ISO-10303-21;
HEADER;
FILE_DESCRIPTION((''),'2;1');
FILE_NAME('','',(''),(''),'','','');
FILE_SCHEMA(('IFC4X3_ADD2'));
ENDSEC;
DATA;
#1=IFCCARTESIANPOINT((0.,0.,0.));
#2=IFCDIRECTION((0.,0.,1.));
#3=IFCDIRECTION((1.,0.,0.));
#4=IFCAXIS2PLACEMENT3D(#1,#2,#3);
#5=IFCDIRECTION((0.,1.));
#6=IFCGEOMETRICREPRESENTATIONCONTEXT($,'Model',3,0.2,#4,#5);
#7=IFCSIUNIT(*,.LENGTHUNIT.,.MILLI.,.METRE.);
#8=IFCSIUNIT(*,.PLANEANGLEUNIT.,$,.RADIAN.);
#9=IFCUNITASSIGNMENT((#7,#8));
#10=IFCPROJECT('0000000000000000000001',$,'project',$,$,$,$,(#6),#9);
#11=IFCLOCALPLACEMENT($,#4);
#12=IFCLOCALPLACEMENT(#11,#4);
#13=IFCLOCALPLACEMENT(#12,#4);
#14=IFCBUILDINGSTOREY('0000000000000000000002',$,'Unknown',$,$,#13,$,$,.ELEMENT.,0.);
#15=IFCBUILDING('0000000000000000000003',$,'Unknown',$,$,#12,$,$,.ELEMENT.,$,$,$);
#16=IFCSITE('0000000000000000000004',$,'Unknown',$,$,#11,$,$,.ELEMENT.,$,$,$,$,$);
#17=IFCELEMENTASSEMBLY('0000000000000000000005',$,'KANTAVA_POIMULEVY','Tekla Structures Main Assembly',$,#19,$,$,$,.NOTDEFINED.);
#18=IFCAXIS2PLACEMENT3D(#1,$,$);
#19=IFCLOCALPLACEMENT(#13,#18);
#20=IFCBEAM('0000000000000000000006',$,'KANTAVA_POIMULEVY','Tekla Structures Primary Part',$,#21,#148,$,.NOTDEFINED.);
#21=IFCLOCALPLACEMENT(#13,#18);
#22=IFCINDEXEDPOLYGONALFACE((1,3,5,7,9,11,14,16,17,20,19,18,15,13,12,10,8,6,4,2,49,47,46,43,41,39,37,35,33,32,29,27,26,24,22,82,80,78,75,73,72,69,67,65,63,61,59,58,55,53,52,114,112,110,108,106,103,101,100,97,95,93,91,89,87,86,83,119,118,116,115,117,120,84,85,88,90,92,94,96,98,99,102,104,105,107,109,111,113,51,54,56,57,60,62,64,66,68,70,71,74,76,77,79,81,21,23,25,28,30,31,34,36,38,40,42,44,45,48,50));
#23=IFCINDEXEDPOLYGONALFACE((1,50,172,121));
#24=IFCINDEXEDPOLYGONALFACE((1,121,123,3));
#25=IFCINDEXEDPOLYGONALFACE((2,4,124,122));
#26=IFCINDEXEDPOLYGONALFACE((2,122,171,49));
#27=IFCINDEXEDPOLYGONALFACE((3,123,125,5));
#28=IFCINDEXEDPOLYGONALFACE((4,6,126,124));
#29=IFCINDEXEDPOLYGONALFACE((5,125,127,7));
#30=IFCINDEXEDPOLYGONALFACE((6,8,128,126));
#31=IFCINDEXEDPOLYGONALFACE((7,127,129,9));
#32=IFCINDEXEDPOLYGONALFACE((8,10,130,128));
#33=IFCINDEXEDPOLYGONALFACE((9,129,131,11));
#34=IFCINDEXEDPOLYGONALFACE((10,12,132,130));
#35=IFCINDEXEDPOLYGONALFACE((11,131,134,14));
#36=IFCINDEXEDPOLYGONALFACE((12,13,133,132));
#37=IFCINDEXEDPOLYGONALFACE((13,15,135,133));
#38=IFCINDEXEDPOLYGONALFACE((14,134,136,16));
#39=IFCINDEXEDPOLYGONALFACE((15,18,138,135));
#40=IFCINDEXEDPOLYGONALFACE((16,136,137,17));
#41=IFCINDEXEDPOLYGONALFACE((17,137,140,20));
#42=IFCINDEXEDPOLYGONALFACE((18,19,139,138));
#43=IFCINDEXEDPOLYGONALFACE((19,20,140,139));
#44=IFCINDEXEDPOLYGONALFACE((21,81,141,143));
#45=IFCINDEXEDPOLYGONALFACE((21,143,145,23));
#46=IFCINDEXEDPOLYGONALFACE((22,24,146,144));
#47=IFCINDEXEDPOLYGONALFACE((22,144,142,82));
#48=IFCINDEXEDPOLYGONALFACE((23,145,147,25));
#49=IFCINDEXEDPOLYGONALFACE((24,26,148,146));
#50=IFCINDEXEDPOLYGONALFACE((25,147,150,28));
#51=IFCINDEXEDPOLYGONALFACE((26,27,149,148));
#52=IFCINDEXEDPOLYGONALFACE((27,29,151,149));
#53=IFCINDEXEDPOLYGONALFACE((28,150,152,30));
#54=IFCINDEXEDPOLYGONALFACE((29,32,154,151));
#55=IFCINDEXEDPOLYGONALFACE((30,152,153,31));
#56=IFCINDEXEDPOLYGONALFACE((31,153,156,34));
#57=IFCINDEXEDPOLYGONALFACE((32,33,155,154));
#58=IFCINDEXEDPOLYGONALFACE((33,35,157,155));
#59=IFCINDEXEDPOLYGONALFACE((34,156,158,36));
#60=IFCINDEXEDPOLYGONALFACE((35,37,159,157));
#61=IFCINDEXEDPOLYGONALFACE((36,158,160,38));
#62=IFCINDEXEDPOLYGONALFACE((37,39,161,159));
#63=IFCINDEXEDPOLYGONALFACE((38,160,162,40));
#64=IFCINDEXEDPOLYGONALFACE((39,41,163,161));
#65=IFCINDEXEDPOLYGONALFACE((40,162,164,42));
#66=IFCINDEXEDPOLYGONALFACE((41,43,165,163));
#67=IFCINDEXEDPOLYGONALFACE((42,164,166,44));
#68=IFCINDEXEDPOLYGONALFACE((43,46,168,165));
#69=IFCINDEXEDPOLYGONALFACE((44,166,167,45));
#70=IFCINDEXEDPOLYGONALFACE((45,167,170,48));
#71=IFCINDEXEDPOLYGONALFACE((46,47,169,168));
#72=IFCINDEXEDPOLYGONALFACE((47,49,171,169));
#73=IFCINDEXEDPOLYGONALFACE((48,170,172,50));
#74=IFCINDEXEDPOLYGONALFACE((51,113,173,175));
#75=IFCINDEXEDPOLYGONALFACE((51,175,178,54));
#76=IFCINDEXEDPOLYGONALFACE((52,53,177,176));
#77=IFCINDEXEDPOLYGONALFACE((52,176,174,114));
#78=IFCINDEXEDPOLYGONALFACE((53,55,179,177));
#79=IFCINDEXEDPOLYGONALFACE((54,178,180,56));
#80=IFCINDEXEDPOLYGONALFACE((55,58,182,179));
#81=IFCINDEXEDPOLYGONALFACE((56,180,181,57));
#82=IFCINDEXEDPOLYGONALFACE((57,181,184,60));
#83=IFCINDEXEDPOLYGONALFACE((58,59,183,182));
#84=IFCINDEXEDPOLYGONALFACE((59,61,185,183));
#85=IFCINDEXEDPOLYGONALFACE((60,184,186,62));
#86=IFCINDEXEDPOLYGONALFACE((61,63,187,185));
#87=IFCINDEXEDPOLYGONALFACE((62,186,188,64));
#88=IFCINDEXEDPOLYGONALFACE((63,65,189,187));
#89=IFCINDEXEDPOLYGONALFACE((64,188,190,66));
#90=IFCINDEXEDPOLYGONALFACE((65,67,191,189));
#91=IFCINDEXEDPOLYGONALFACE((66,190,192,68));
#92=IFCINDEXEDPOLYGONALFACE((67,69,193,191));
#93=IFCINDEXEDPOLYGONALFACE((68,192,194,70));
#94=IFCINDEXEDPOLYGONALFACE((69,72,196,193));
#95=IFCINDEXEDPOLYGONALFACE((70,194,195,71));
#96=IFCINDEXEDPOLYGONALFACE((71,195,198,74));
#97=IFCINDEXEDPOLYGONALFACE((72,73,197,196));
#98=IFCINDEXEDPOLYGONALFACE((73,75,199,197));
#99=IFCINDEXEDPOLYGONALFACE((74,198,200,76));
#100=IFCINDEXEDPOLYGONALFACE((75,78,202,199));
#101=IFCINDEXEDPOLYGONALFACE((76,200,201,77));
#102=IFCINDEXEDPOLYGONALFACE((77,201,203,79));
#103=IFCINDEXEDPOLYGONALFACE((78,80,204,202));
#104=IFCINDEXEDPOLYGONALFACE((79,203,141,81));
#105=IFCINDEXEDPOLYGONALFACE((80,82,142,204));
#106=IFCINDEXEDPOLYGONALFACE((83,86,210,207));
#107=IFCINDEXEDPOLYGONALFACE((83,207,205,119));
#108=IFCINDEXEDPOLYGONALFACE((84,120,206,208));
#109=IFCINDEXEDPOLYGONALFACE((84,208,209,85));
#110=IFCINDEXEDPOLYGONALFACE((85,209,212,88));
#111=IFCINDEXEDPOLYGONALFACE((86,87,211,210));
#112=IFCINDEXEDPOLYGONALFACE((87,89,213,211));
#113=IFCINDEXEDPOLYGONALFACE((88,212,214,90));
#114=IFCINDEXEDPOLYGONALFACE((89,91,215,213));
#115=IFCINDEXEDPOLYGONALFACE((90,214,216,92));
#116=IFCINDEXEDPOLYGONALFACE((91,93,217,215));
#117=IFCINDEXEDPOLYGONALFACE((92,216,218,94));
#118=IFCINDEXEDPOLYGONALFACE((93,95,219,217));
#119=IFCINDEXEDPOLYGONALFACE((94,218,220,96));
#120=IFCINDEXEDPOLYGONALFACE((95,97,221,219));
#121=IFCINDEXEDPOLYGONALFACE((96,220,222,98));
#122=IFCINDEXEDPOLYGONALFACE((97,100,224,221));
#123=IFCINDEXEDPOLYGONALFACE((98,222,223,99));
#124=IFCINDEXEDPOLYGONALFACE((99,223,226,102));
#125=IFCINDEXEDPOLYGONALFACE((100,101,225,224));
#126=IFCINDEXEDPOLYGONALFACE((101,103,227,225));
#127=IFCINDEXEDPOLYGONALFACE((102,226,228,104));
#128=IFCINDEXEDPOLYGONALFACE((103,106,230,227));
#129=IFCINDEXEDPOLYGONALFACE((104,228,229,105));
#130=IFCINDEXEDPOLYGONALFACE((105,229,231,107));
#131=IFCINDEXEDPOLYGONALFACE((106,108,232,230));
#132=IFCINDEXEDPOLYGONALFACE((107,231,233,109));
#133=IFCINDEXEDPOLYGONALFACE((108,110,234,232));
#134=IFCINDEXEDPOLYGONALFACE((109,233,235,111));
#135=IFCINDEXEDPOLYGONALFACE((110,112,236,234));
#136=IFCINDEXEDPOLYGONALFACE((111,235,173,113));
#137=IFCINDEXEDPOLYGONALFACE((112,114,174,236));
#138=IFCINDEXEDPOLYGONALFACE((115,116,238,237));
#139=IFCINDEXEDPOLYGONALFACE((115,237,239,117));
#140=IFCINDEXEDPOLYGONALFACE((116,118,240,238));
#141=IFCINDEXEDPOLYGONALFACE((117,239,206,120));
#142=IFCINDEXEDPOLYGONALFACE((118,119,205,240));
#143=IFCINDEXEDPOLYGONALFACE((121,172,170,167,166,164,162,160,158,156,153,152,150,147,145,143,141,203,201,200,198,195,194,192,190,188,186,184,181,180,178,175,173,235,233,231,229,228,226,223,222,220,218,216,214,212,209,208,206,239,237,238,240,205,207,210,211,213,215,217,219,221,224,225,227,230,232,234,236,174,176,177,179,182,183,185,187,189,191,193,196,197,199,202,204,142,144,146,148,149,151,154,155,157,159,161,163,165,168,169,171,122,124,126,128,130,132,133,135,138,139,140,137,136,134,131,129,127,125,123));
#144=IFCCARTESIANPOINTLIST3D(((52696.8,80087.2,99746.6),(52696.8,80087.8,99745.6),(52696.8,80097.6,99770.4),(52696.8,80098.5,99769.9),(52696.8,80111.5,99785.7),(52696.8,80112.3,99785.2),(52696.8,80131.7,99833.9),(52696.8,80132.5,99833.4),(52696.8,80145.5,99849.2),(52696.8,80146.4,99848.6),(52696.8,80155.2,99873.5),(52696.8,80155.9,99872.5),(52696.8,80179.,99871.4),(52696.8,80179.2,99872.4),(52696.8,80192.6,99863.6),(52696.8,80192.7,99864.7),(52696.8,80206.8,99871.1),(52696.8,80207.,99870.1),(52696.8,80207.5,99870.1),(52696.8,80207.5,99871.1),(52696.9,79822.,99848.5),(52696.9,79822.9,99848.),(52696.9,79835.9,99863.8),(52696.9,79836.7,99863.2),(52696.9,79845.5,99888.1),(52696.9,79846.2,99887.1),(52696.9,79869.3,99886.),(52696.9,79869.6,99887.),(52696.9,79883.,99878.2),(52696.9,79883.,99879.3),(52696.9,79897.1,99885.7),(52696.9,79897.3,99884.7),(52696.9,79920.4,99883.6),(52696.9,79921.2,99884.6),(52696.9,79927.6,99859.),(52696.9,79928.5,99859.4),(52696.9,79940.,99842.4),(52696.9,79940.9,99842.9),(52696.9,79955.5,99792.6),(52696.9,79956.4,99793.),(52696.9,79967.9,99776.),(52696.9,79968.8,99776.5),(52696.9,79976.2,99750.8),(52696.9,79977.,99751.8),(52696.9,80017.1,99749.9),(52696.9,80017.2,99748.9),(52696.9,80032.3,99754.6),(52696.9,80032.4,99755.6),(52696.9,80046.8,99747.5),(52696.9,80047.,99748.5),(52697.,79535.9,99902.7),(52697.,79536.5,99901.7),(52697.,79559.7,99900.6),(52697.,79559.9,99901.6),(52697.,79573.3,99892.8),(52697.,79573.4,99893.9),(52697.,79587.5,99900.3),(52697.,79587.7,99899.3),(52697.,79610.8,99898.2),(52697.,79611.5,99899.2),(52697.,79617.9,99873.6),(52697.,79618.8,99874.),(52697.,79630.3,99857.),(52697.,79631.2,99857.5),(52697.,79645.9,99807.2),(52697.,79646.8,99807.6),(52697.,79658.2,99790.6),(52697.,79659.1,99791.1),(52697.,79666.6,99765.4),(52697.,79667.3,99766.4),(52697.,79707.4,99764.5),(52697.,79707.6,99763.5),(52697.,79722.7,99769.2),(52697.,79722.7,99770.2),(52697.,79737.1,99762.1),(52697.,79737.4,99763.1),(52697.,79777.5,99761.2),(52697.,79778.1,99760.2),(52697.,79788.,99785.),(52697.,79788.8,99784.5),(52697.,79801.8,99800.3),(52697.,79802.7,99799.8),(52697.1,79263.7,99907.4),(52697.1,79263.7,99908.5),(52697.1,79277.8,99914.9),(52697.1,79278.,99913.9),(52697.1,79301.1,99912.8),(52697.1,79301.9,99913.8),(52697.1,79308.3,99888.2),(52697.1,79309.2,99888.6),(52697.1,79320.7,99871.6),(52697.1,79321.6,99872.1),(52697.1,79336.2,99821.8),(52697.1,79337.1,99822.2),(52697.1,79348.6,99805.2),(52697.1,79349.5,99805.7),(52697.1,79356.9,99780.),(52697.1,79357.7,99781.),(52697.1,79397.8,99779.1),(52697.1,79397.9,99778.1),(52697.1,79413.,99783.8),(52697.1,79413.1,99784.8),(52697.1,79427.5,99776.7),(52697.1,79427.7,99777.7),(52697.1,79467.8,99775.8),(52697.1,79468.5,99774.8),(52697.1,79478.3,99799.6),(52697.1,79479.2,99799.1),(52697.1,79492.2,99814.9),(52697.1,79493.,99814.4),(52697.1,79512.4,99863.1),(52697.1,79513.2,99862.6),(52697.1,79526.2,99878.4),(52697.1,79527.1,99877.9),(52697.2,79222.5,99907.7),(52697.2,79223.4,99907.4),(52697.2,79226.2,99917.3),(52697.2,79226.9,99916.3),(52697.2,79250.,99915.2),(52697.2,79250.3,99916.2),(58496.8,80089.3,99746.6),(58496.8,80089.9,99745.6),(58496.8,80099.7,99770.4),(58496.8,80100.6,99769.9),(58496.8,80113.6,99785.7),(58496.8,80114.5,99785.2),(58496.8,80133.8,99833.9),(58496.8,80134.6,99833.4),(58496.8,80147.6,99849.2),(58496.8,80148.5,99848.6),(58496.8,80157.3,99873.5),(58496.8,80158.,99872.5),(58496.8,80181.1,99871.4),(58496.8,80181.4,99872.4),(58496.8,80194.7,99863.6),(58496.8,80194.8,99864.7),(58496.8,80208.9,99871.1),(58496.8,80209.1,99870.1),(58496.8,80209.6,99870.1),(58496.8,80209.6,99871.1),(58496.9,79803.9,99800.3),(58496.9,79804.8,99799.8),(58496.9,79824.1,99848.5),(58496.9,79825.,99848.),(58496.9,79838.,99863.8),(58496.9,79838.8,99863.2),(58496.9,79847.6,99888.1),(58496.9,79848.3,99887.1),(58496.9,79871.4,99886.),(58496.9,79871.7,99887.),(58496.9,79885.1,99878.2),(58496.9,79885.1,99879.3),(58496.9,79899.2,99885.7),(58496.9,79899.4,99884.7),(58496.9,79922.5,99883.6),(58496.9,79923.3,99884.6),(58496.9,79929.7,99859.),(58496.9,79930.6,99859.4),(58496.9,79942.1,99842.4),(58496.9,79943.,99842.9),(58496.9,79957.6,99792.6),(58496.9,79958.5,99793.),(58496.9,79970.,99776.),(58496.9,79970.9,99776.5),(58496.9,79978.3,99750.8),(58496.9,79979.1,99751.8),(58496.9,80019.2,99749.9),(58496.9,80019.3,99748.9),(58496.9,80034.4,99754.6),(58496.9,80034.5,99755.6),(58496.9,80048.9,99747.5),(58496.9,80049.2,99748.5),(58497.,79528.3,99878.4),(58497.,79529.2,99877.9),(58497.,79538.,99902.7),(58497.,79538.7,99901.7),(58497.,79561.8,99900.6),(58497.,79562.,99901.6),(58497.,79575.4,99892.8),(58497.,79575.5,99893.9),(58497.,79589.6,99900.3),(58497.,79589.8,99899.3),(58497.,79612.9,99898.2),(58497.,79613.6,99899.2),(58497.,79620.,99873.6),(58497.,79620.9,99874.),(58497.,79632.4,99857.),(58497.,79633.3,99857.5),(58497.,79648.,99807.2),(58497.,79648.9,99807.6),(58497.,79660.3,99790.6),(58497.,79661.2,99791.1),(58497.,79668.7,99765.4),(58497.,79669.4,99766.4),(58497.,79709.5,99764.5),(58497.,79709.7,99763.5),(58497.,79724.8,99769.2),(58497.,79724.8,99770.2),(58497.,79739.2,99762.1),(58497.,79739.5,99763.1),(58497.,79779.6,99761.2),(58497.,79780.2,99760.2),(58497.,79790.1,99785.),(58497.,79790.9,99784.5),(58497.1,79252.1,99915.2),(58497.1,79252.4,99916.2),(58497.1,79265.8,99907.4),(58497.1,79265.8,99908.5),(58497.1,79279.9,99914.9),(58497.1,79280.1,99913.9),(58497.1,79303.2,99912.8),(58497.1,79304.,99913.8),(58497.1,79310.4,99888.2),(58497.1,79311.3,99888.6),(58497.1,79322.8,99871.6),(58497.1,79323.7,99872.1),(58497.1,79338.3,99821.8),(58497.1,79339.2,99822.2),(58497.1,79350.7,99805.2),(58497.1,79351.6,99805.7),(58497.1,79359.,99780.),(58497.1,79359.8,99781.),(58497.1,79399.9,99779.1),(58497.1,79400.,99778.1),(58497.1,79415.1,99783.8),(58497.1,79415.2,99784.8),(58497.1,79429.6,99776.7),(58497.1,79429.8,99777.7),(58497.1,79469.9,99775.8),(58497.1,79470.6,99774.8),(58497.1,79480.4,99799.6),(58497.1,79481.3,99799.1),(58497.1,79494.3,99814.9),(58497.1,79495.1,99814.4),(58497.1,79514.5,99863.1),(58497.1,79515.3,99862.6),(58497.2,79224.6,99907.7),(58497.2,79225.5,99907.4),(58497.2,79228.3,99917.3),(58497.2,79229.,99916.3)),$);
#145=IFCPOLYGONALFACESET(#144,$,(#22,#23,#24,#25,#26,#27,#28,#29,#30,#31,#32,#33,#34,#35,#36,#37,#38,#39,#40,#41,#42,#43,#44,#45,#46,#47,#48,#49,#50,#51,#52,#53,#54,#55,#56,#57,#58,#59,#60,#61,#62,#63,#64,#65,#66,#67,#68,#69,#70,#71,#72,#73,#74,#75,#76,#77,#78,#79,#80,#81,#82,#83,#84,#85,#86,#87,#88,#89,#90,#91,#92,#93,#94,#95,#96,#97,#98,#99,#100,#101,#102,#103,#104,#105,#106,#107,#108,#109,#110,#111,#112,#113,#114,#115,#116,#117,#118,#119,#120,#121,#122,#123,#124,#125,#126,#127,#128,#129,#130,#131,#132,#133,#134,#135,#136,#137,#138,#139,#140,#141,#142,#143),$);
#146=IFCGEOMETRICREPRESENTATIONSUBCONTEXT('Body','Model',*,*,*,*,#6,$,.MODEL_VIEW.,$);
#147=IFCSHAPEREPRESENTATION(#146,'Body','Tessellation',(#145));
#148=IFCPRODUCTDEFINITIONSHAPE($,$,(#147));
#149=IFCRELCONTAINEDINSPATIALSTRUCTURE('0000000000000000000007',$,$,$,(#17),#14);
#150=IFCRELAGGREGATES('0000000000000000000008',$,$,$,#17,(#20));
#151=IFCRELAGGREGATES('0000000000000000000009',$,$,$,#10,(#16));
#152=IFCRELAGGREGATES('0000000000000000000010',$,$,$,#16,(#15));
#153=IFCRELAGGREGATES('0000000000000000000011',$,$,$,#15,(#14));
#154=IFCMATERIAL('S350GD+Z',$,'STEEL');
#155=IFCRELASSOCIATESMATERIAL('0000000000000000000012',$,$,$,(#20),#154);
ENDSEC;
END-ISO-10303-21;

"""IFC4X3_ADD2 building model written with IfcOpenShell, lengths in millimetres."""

from ifc_helpers import new_model, si_unit, direction, frame, origin_with_axes, place, context, subcontext, project, spatial, line, indexed_curve, outline, extrude, material, element, aggregate, save


model = new_model("IFC4X3_ADD2")

# Units and contexts
model_context = context("Model", 3, precision=0.2, world=origin_with_axes(), true_north=direction((0.0, 1.0)))
body_context = subcontext(model_context, "Body", "Model", "MODEL_VIEW")
ifc_project = project(units=[si_unit("LENGTHUNIT", "METRE", prefix="MILLI"), si_unit("PLANEANGLEUNIT", "RADIAN")], contexts=[model_context])

# Site, building, storey
site_placement = place(None, origin_with_axes())
site = spatial("IfcSite", under=ifc_project, at=site_placement, Name="Unknown", CompositionType="ELEMENT")
building_placement = place(site_placement, origin_with_axes())
building = spatial("IfcBuilding", under=site, at=building_placement, Name="Unknown", CompositionType="ELEMENT")
storey_placement = place(building_placement, origin_with_axes())
storey = spatial("IfcBuildingStorey", under=building, at=storey_placement, Name="Unknown", CompositionType="ELEMENT", Elevation=0.0)

# Element assembly, beam
ifc_material_1 = material(Name="S350GD+Z", Category="STEEL")
assembly_1_placement = place(storey_placement, frame((58497.0, 79727.5, 99828.2), z_axis=(-0.000363, 0.99889, -0.047106), x_axis=(-1.0, -0.000363, 0.0)))
assembly_1 = element("IfcElementAssembly", 1, at=assembly_1_placement, inside=storey, Name="KANTAVA_POIMULEVY", Description="Tekla Structures Main Assembly", PredefinedType="NOTDEFINED")
beam_1_placement = place(assembly_1_placement, origin_with_axes())
beam_1 = element("IfcBeam", 2, at=beam_1_placement, material=ifc_material_1, Name="KANTAVA_POIMULEVY", Description="Tekla Structures Primary Part", PredefinedType="NOTDEFINED", context=body_context, shape_type="SolidModel", body=[
    extrude(outline(indexed_curve([(479.5, 65.5), (478.8, 65.5), (465.0, 58.5), (451.2, 65.5), (427.1, 65.5), (418.6, 40.7), (405.5, 24.8), (387.6, -24.3), (374.5, -40.2), (365.1, -64.5), (325.0, -64.5), (310.0, -58.1), (295.0, -64.5), (254.8, -64.5), (245.5, -40.2), (232.4, -24.3), (214.5, 24.8), (201.4, 40.7), (192.9, 65.5), (168.8, 65.5), (155.0, 58.5), (141.2, 65.5), (117.1, 65.5), (108.6, 40.7), (95.5, 24.8), (77.6, -24.3), (64.5, -40.2), (55.1, -64.5), (15.0, -64.5), (0.0, -58.1), (-15.0, -64.5), (-55.2, -64.5), (-64.5, -40.2), (-77.6, -24.3), (-95.5, 24.8), (-108.6, 40.7), (-117.2, 65.5), (-141.2, 65.5), (-155.0, 58.5), (-168.8, 65.5), (-192.9, 65.5), (-201.4, 40.7), (-214.5, 24.8), (-232.4, -24.3), (-245.5, -40.2), (-254.9, -64.5), (-295.0, -64.5), (-310.0, -58.1), (-325.0, -64.5), (-365.2, -64.5), (-374.5, -40.2), (-387.6, -24.3), (-405.5, 24.8), (-418.6, 40.7), (-427.1, 65.5), (-451.2, 65.5), (-465.0, 58.5), (-478.8, 65.5), (-502.9, 65.5), (-506.2, 55.7), (-505.2, 55.4), (-502.1, 64.5), (-479.0, 64.5), (-465.0, 57.3), (-451.0, 64.5), (-427.9, 64.5), (-419.5, 40.2), (-406.4, 24.3), (-388.5, -24.8), (-375.4, -40.7), (-365.9, -65.5), (-324.8, -65.5), (-310.0, -59.1), (-295.2, -65.5), (-254.2, -65.5), (-244.6, -40.7), (-231.5, -24.8), (-213.6, 24.3), (-200.5, 40.2), (-192.1, 64.5), (-169.0, 64.5), (-155.0, 57.3), (-141.0, 64.5), (-117.9, 64.5), (-109.5, 40.2), (-96.4, 24.3), (-78.5, -24.8), (-65.4, -40.7), (-55.9, -65.5), (-14.8, -65.5), (0.0, -59.1), (14.8, -65.5), (55.8, -65.5), (65.4, -40.7), (78.5, -24.8), (96.4, 24.3), (109.5, 40.2), (117.8, 64.5), (141.0, 64.5), (155.0, 57.3), (169.0, 64.5), (192.1, 64.5), (200.5, 40.2), (213.6, 24.3), (231.5, -24.8), (244.6, -40.7), (254.1, -65.5), (295.2, -65.5), (310.0, -59.1), (324.8, -65.5), (365.8, -65.5), (375.4, -40.7), (388.5, -24.8), (406.4, 24.3), (419.5, 40.2), (427.9, 64.5), (451.0, 64.5), (465.0, 57.3), (479.0, 64.5), (479.5, 64.5)], segments=[line(1, 2, 3, 4, 5, 6, 7, 8, 9, 10, 11, 12, 13, 14, 15, 16, 17, 18, 19, 20, 21, 22, 23, 24, 25, 26, 27, 28, 29, 30, 31, 32, 33, 34, 35, 36, 37, 38, 39, 40, 41, 42, 43, 44, 45, 46, 47, 48, 49, 50, 51, 52, 53, 54, 55, 56, 57, 58, 59, 60, 61, 62, 63, 64, 65, 66, 67, 68, 69, 70, 71, 72, 73, 74, 75, 76, 77, 78, 79, 80, 81, 82, 83, 84, 85, 86, 87, 88, 89, 90, 91, 92, 93, 94, 95, 96, 97, 98, 99, 100, 101, 102, 103, 104, 105, 106, 107, 108, 109, 110, 111, 112, 113, 114, 115, 116, 117, 118, 119, 120, 1)])), frame((0.0, 0.0, 0.0), z_axis=(-1.0, 0.0, 0.0), x_axis=(0.0, 0.0, 1.0)), (0.0, 0.0, -1.0), 5800.0),
])
aggregate(assembly_1, [beam_1])

save(model, "model.ifc")
